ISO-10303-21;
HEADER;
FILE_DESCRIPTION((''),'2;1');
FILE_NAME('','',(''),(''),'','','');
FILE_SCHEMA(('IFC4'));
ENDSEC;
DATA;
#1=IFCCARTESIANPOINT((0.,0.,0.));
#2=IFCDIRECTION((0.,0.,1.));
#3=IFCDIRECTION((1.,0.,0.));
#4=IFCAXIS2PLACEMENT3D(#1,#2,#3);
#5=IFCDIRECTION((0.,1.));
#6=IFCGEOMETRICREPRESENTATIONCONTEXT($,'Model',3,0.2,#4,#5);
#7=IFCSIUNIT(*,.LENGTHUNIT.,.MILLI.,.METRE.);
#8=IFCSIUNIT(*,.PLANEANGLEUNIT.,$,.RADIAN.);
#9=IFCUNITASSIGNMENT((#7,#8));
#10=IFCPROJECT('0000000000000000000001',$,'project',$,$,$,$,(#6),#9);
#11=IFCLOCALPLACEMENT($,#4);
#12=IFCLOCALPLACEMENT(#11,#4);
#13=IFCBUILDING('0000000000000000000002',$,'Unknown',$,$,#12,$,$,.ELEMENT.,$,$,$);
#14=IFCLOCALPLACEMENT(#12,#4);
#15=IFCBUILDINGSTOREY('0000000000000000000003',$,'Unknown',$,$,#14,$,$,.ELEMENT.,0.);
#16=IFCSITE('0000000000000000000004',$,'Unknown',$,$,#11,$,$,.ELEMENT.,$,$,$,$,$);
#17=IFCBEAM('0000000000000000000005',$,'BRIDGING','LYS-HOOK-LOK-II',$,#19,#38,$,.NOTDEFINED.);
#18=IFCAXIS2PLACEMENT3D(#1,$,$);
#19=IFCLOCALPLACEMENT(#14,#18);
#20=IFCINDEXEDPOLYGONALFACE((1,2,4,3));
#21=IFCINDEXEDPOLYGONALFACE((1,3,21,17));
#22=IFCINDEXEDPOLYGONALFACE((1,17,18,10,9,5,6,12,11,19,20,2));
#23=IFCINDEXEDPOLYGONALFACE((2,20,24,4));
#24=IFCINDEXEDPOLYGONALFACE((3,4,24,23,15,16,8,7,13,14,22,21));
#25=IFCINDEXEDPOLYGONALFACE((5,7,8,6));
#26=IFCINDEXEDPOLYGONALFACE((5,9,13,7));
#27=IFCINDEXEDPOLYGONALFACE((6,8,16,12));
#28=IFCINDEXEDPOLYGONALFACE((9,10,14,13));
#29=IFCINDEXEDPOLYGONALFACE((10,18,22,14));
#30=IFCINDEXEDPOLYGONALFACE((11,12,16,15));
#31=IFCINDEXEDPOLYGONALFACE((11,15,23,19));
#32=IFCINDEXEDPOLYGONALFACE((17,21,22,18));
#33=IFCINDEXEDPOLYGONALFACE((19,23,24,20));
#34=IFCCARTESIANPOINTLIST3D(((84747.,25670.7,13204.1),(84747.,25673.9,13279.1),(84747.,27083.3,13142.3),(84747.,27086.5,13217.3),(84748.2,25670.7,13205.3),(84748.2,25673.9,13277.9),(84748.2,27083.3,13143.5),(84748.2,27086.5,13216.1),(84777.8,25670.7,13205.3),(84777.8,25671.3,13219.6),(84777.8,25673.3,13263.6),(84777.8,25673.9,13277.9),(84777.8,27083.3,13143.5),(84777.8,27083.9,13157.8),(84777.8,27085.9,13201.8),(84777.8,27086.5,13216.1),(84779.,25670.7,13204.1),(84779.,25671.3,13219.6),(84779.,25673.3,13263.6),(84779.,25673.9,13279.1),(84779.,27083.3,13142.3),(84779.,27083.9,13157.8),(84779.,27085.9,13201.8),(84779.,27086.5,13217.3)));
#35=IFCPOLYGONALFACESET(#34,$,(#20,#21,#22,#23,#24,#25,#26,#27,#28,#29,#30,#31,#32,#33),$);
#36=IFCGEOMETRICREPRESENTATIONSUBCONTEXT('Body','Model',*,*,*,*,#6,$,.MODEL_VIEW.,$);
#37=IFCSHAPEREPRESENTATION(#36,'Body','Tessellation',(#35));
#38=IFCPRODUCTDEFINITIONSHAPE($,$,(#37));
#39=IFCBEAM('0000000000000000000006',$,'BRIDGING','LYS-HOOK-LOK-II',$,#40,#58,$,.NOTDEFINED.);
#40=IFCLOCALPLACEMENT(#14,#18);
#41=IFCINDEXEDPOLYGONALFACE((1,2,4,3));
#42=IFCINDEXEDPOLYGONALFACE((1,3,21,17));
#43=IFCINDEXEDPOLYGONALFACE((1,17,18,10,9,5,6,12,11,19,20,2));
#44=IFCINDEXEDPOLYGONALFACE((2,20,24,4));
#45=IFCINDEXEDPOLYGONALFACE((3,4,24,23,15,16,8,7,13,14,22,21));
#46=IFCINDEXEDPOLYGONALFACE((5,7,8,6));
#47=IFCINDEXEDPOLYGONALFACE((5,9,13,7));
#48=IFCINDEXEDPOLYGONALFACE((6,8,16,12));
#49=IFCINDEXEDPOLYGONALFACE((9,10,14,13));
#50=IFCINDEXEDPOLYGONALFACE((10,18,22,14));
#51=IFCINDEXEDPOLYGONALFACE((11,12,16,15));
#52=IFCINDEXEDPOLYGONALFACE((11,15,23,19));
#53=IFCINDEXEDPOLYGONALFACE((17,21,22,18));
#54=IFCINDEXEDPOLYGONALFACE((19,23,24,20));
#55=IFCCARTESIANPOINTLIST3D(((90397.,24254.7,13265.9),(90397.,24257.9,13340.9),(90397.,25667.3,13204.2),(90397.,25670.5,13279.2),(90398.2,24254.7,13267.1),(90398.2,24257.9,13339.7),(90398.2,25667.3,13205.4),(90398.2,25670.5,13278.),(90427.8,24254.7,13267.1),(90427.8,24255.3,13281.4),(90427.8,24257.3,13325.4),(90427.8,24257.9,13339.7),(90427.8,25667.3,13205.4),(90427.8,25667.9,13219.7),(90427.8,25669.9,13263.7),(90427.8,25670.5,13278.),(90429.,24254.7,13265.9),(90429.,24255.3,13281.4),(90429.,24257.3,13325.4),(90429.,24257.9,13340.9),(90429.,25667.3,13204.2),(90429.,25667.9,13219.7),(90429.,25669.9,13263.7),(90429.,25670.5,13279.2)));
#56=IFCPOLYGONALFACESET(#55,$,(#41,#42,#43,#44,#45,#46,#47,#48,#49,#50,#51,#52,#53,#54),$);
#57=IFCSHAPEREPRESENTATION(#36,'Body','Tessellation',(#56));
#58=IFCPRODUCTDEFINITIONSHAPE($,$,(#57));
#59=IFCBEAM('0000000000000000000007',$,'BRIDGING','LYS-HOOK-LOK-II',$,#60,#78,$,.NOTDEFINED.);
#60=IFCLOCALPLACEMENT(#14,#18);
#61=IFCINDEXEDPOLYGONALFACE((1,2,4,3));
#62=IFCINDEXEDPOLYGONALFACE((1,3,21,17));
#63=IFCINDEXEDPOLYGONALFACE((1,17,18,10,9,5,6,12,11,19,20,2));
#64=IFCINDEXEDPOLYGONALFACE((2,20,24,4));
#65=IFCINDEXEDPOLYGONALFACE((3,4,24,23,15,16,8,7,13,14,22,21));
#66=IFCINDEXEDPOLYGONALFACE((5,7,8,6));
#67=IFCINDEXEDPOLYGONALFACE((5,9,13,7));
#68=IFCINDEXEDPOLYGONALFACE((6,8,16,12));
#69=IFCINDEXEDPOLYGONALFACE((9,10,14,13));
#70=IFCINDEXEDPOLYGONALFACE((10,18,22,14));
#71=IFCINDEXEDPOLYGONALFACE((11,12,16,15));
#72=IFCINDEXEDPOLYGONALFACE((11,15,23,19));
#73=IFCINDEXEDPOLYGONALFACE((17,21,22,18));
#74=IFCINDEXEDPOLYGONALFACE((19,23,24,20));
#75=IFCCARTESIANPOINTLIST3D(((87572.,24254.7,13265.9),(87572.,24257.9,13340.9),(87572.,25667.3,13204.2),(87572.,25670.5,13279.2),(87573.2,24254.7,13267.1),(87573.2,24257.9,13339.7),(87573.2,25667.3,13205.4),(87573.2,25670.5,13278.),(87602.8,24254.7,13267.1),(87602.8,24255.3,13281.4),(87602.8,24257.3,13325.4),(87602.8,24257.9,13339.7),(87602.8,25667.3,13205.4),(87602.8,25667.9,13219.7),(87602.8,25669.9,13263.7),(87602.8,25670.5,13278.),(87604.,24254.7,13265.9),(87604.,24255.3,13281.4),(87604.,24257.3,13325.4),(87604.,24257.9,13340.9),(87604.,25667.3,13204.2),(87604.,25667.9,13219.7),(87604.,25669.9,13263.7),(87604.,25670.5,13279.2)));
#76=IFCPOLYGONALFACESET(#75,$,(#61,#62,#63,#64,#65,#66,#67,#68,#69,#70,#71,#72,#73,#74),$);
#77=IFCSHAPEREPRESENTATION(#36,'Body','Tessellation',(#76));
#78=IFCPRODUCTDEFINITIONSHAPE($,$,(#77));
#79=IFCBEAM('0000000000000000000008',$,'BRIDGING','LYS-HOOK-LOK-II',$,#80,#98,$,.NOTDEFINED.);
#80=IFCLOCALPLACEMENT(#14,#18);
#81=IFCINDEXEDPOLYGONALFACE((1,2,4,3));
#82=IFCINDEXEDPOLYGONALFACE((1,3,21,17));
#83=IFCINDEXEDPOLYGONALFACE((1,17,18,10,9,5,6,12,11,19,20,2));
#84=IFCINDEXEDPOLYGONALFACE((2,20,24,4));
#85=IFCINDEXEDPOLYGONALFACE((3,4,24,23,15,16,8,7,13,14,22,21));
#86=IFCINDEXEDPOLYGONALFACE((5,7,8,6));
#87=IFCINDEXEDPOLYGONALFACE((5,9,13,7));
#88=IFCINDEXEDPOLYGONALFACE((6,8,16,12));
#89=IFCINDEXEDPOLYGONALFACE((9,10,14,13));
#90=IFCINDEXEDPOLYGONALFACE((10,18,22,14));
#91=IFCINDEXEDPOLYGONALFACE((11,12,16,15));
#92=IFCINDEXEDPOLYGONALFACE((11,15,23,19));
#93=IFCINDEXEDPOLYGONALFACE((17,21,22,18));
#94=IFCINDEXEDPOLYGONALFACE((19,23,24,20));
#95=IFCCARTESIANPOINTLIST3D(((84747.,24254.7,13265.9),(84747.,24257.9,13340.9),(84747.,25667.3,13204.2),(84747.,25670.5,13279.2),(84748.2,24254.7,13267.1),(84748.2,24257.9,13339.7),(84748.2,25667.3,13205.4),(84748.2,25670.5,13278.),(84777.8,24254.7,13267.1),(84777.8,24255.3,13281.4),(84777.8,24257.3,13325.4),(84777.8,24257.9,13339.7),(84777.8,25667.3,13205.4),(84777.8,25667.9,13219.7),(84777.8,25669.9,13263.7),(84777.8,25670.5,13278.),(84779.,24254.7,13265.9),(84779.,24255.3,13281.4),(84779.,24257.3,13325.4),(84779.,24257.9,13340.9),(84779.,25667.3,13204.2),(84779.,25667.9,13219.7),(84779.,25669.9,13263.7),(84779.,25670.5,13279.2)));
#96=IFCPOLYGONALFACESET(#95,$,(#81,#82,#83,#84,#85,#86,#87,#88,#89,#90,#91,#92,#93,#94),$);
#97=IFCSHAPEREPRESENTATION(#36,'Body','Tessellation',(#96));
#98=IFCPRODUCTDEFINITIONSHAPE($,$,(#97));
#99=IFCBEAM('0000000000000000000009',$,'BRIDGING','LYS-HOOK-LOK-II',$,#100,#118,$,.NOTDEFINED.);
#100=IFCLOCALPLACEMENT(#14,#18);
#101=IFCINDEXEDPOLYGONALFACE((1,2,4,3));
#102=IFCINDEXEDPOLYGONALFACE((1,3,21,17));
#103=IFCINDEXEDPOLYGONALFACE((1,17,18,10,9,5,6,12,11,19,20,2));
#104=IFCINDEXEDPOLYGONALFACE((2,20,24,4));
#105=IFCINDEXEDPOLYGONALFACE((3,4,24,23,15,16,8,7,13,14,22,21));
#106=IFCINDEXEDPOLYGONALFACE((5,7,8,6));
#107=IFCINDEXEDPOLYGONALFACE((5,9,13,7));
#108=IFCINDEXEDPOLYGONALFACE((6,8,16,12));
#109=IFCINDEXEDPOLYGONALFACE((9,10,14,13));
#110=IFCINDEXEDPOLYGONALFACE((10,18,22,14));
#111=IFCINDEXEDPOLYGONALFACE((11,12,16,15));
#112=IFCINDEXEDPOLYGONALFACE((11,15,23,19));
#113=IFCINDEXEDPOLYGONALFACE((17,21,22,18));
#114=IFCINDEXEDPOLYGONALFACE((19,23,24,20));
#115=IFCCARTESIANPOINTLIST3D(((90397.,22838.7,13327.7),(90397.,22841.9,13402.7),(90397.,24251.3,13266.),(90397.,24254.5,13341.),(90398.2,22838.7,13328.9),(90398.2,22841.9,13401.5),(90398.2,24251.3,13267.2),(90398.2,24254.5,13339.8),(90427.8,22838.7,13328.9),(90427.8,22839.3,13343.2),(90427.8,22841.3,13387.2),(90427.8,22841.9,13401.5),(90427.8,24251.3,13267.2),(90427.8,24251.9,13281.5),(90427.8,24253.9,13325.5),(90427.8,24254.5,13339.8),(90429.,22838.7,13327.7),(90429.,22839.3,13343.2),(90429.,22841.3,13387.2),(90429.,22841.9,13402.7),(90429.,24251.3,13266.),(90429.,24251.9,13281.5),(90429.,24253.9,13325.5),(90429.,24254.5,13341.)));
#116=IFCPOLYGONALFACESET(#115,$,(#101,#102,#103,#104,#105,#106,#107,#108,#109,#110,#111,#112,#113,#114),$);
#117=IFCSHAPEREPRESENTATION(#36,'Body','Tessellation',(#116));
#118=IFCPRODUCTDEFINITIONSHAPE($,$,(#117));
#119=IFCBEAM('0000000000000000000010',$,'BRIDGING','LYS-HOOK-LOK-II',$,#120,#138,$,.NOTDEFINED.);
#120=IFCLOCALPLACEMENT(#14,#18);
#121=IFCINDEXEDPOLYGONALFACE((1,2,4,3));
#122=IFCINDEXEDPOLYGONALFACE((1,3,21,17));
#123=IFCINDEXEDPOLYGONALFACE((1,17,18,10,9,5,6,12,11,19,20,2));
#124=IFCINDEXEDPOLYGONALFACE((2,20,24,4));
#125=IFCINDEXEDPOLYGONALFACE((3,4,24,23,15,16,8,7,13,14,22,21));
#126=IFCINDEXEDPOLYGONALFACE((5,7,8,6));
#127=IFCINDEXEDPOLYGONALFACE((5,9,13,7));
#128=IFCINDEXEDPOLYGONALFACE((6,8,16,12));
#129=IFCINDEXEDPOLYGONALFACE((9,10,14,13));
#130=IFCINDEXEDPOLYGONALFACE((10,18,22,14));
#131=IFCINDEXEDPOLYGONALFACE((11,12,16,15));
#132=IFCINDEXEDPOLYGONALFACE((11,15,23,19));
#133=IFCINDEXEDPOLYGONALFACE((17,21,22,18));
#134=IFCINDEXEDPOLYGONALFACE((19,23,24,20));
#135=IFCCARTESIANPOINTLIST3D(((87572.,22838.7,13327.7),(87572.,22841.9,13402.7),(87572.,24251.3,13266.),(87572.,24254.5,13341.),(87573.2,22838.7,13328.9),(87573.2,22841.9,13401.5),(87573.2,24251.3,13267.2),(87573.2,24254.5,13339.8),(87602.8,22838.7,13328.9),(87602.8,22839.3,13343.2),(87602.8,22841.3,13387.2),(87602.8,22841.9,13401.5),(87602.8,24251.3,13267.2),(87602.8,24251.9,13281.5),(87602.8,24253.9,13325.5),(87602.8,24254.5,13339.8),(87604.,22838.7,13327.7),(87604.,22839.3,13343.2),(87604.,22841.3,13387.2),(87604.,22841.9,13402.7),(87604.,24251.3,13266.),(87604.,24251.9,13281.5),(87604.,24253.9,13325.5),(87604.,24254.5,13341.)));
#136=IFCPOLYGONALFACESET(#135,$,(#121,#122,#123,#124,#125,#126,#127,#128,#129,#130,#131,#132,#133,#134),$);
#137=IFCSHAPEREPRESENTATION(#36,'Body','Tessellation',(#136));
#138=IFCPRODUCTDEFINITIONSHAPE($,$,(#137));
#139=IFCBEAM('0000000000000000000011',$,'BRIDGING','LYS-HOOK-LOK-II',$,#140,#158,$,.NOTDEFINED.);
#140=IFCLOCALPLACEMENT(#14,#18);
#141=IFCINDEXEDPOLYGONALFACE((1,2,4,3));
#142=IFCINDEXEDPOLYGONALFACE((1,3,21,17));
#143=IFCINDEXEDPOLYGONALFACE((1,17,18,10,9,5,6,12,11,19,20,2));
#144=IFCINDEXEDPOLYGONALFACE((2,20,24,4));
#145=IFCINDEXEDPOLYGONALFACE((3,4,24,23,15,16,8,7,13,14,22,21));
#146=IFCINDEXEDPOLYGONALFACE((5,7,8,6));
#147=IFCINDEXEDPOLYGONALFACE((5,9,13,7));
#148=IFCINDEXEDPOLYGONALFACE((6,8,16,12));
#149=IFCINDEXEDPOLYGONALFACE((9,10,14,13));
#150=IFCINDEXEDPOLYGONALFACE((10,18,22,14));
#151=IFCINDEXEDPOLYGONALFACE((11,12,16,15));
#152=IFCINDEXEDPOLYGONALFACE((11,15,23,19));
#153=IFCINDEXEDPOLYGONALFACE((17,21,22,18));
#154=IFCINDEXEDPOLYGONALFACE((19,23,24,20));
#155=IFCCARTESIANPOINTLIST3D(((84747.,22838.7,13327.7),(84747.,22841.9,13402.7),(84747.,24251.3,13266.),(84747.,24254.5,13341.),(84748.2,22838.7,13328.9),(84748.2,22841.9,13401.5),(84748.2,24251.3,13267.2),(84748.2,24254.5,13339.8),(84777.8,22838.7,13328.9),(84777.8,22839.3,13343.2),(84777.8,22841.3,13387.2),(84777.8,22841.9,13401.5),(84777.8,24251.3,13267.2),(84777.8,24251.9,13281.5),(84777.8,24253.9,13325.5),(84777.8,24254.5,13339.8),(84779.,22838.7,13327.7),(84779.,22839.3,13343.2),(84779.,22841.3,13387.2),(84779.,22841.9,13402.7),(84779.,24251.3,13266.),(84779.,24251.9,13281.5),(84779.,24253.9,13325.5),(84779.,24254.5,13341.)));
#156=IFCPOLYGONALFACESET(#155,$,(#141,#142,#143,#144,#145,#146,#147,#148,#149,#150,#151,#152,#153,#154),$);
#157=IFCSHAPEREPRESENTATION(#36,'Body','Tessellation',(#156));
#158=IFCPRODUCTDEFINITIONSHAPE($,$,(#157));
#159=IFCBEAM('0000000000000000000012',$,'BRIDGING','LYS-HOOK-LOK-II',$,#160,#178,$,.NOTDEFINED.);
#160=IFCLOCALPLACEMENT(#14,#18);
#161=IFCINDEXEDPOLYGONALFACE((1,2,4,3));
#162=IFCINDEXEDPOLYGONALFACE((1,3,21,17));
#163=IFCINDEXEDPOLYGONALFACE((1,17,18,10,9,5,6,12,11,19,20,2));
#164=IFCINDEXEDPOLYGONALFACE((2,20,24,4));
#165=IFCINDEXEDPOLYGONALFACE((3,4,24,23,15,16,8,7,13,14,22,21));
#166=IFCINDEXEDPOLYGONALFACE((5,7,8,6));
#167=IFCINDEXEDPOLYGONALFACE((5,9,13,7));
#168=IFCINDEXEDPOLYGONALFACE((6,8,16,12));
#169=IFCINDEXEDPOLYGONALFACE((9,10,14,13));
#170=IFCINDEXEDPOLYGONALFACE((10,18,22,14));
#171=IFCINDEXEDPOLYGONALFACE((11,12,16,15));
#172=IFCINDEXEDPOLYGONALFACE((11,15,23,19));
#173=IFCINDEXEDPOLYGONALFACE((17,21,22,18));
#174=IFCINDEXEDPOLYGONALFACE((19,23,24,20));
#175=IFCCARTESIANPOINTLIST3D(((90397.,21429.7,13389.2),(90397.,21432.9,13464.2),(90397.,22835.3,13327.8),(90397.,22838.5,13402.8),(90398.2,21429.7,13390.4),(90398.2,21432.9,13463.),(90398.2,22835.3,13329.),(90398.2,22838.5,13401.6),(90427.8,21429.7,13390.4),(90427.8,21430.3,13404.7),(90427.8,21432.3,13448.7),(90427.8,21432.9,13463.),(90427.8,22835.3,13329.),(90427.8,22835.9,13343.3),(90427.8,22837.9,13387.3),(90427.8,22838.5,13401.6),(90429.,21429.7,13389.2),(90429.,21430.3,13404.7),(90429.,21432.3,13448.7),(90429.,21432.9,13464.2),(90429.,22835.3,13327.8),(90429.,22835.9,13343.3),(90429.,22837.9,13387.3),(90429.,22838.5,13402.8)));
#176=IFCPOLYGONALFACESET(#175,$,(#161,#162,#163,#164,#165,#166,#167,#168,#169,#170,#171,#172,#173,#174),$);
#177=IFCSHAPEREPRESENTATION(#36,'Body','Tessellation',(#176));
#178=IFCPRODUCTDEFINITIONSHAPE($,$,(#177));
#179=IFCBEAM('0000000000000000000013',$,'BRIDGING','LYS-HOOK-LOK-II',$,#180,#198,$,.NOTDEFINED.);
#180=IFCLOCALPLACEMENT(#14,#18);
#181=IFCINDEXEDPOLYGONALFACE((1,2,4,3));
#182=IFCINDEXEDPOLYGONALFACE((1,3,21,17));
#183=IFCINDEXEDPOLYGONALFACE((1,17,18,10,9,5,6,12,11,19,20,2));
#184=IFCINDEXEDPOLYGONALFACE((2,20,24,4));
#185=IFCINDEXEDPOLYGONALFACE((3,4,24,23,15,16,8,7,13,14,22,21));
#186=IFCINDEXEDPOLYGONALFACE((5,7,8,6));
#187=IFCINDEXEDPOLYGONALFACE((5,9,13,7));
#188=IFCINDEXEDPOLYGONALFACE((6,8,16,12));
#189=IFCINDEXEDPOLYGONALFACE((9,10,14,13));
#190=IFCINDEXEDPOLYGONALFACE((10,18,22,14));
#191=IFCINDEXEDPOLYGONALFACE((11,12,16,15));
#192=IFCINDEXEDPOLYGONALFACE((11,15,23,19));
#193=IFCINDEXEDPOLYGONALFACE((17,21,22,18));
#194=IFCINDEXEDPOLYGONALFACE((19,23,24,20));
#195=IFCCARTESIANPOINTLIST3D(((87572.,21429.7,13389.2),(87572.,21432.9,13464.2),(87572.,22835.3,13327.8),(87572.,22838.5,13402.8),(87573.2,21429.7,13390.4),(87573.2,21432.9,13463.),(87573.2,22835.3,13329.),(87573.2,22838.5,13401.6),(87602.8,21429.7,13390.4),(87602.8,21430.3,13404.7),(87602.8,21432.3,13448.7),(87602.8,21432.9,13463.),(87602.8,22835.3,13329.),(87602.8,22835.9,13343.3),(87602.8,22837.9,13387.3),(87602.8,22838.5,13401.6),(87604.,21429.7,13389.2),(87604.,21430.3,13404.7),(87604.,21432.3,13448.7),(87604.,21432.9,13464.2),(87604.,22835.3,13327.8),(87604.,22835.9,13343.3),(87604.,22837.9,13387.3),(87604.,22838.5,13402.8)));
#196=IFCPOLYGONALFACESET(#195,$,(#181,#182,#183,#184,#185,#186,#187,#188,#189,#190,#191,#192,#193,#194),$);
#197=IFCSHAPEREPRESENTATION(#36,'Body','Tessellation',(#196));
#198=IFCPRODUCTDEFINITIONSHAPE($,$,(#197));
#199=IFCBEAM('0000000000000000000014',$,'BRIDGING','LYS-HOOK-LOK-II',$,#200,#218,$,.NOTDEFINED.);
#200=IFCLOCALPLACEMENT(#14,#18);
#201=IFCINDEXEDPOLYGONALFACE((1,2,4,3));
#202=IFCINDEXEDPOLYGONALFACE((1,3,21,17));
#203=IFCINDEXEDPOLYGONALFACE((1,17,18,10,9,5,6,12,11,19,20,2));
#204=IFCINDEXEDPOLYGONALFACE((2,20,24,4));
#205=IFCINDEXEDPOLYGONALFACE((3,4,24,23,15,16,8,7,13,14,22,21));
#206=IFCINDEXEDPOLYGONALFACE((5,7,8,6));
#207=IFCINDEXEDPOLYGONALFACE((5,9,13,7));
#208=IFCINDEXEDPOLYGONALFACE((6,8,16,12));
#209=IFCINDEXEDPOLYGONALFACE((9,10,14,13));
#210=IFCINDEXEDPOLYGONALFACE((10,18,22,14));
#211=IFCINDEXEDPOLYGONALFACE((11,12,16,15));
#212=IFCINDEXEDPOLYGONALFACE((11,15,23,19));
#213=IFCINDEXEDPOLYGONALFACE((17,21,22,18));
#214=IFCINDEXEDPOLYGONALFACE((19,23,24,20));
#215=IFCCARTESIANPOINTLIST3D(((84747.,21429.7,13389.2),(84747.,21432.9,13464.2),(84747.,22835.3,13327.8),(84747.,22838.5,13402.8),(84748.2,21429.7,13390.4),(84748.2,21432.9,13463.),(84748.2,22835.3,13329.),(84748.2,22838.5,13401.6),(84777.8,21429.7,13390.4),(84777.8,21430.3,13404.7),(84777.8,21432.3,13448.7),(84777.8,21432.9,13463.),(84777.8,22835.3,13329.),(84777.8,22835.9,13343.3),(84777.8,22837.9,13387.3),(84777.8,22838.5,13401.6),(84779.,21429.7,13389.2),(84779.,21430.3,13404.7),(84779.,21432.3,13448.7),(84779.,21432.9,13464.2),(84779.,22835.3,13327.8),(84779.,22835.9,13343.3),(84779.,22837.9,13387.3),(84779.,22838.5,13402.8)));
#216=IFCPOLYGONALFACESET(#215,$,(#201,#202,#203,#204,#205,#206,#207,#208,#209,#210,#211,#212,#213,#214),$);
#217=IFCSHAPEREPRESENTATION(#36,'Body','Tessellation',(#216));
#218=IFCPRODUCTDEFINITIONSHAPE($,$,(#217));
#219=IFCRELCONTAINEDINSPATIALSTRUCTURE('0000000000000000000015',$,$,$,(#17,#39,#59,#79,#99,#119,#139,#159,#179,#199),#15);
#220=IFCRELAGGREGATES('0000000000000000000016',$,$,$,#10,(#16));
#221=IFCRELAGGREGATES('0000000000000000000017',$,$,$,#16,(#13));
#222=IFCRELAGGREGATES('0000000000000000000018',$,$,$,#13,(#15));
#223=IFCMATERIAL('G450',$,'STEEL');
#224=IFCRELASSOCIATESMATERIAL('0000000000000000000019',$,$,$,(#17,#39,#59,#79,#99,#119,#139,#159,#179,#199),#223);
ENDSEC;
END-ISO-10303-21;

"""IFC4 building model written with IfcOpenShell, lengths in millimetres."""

from ifc_helpers import new_model, si_unit, direction, frame, origin_with_axes, place, context, subcontext, project, spatial, line, indexed_curve, outline, extrude, material, element, save


model = new_model("IFC4")

# Units and contexts
model_context = context("Model", 3, precision=0.2, world=origin_with_axes(), true_north=direction((0.0, 1.0)))
body_context = subcontext(model_context, "Body", "Model", "MODEL_VIEW")
ifc_project = project(units=[si_unit("LENGTHUNIT", "METRE", prefix="MILLI"), si_unit("PLANEANGLEUNIT", "RADIAN")], contexts=[model_context])

# Site, building, storey
site_placement = place(None, origin_with_axes())
site = spatial("IfcSite", under=ifc_project, at=site_placement, Name="Unknown", CompositionType="ELEMENT")
building_placement = place(site_placement, origin_with_axes())
building = spatial("IfcBuilding", under=site, at=building_placement, Name="Unknown", CompositionType="ELEMENT")
storey_placement = place(building_placement, origin_with_axes())
storey = spatial("IfcBuildingStorey", under=building, at=storey_placement, Name="Unknown", CompositionType="ELEMENT", Elevation=0.0)

# Beams
ifc_material_1 = material(Name="G450", Category="STEEL")
for number, where, z_axis, x_axis, name in (
    (1, (84763.0, 25672.3, 13241.6), (1.0, 0.0, 0.0), (0.0, 0.999044, -0.043707), "BRIDGING"),
):
    element("IfcBeam", number, at=place(storey_placement, frame(where, z_axis=z_axis, x_axis=x_axis)), inside=storey, material=ifc_material_1, Name=name, Description="LYS-HOOK-LOK-II", PredefinedType="NOTDEFINED", context=body_context, shape_type="SolidModel", body=[
        extrude(outline(indexed_curve([(16.0, -37.5), (16.0, -22.0), (14.8, -22.0), (14.8, -36.3), (-14.8, -36.3), (-14.8, 36.3), (14.8, 36.3), (14.8, 22.0), (16.0, 22.0), (16.0, 37.5), (-16.0, 37.5), (-16.0, -37.5)], segments=[line(1, 2, 3, 4, 5, 6, 7, 8, 9, 10, 11, 12, 1)])), frame((0.0, 0.0, 0.0), z_axis=(-1.0, 0.0, 0.0), x_axis=(0.0, 0.0, 1.0)), (0.0, 0.0, -1.0), 1414.0),
    ])
for number, where, z_axis, x_axis, name in (
    (2, (90413.0, 24256.3, 13303.4), (1.0, 0.0, 0.0), (0.0, 0.999047, -0.043637), "BRIDGING"),
    (3, (87588.0, 24256.3, 13303.4), (1.0, 0.0, 0.0), (0.0, 0.999047, -0.043637), "BRIDGING"),
    (4, (84763.0, 24256.3, 13303.4), (1.0, 0.0, 0.0), (0.0, 0.999047, -0.043637), "BRIDGING"),
    (5, (90413.0, 22840.3, 13365.2), (1.0, 0.0, 0.0), (0.0, 0.999047, -0.043637), "BRIDGING"),
    (6, (87588.0, 22840.3, 13365.2), (1.0, 0.0, 0.0), (0.0, 0.999047, -0.043637), "BRIDGING"),
    (7, (84763.0, 22840.3, 13365.2), (1.0, 0.0, 0.0), (0.0, 0.999047, -0.043637), "BRIDGING"),
):
    element("IfcBeam", number, at=place(storey_placement, frame(where, z_axis=z_axis, x_axis=x_axis)), inside=storey, material=ifc_material_1, Name=name, Description="LYS-HOOK-LOK-II", PredefinedType="NOTDEFINED", context=body_context, shape_type="SolidModel", body=[
        extrude(outline(indexed_curve([(16.0, -37.5), (16.0, -22.0), (14.8, -22.0), (14.8, -36.3), (-14.8, -36.3), (-14.8, 36.3), (14.8, 36.3), (14.8, 22.0), (16.0, 22.0), (16.0, 37.5), (-16.0, 37.5), (-16.0, -37.5)], segments=[line(1, 2, 3, 4, 5, 6, 7, 8, 9, 10, 11, 12, 1)])), frame((0.0, 0.0, 0.0), z_axis=(-1.0, 0.0, 0.0), x_axis=(0.0, 0.0, 1.0)), (0.0, 0.0, -1.0), 1413.9),
    ])
for number, where, z_axis, x_axis, name in (
    (8, (90413.0, 21431.3, 13426.7), (1.0, 0.0, 0.0), (0.0, 0.999047, -0.043641), "BRIDGING"),
    (9, (87588.0, 21431.3, 13426.7), (1.0, 0.0, 0.0), (0.0, 0.999047, -0.043641), "BRIDGING"),
    (10, (84763.0, 21431.3, 13426.7), (1.0, 0.0, 0.0), (0.0, 0.999047, -0.043641), "BRIDGING"),
):
    element("IfcBeam", number, at=place(storey_placement, frame(where, z_axis=z_axis, x_axis=x_axis)), inside=storey, material=ifc_material_1, Name=name, Description="LYS-HOOK-LOK-II", PredefinedType="NOTDEFINED", context=body_context, shape_type="SolidModel", body=[
        extrude(outline(indexed_curve([(16.0, -37.5), (16.0, -22.0), (14.8, -22.0), (14.8, -36.3), (-14.8, -36.3), (-14.8, 36.3), (14.8, 36.3), (14.8, 22.0), (16.0, 22.0), (16.0, 37.5), (-16.0, 37.5), (-16.0, -37.5)], segments=[line(1, 2, 3, 4, 5, 6, 7, 8, 9, 10, 11, 12, 1)])), frame((0.0, 0.0, 0.0), z_axis=(-1.0, 0.0, 0.0), x_axis=(0.0, 0.0, 1.0)), (0.0, 0.0, -1.0), 1406.9),
    ])

save(model, "model.ifc")
